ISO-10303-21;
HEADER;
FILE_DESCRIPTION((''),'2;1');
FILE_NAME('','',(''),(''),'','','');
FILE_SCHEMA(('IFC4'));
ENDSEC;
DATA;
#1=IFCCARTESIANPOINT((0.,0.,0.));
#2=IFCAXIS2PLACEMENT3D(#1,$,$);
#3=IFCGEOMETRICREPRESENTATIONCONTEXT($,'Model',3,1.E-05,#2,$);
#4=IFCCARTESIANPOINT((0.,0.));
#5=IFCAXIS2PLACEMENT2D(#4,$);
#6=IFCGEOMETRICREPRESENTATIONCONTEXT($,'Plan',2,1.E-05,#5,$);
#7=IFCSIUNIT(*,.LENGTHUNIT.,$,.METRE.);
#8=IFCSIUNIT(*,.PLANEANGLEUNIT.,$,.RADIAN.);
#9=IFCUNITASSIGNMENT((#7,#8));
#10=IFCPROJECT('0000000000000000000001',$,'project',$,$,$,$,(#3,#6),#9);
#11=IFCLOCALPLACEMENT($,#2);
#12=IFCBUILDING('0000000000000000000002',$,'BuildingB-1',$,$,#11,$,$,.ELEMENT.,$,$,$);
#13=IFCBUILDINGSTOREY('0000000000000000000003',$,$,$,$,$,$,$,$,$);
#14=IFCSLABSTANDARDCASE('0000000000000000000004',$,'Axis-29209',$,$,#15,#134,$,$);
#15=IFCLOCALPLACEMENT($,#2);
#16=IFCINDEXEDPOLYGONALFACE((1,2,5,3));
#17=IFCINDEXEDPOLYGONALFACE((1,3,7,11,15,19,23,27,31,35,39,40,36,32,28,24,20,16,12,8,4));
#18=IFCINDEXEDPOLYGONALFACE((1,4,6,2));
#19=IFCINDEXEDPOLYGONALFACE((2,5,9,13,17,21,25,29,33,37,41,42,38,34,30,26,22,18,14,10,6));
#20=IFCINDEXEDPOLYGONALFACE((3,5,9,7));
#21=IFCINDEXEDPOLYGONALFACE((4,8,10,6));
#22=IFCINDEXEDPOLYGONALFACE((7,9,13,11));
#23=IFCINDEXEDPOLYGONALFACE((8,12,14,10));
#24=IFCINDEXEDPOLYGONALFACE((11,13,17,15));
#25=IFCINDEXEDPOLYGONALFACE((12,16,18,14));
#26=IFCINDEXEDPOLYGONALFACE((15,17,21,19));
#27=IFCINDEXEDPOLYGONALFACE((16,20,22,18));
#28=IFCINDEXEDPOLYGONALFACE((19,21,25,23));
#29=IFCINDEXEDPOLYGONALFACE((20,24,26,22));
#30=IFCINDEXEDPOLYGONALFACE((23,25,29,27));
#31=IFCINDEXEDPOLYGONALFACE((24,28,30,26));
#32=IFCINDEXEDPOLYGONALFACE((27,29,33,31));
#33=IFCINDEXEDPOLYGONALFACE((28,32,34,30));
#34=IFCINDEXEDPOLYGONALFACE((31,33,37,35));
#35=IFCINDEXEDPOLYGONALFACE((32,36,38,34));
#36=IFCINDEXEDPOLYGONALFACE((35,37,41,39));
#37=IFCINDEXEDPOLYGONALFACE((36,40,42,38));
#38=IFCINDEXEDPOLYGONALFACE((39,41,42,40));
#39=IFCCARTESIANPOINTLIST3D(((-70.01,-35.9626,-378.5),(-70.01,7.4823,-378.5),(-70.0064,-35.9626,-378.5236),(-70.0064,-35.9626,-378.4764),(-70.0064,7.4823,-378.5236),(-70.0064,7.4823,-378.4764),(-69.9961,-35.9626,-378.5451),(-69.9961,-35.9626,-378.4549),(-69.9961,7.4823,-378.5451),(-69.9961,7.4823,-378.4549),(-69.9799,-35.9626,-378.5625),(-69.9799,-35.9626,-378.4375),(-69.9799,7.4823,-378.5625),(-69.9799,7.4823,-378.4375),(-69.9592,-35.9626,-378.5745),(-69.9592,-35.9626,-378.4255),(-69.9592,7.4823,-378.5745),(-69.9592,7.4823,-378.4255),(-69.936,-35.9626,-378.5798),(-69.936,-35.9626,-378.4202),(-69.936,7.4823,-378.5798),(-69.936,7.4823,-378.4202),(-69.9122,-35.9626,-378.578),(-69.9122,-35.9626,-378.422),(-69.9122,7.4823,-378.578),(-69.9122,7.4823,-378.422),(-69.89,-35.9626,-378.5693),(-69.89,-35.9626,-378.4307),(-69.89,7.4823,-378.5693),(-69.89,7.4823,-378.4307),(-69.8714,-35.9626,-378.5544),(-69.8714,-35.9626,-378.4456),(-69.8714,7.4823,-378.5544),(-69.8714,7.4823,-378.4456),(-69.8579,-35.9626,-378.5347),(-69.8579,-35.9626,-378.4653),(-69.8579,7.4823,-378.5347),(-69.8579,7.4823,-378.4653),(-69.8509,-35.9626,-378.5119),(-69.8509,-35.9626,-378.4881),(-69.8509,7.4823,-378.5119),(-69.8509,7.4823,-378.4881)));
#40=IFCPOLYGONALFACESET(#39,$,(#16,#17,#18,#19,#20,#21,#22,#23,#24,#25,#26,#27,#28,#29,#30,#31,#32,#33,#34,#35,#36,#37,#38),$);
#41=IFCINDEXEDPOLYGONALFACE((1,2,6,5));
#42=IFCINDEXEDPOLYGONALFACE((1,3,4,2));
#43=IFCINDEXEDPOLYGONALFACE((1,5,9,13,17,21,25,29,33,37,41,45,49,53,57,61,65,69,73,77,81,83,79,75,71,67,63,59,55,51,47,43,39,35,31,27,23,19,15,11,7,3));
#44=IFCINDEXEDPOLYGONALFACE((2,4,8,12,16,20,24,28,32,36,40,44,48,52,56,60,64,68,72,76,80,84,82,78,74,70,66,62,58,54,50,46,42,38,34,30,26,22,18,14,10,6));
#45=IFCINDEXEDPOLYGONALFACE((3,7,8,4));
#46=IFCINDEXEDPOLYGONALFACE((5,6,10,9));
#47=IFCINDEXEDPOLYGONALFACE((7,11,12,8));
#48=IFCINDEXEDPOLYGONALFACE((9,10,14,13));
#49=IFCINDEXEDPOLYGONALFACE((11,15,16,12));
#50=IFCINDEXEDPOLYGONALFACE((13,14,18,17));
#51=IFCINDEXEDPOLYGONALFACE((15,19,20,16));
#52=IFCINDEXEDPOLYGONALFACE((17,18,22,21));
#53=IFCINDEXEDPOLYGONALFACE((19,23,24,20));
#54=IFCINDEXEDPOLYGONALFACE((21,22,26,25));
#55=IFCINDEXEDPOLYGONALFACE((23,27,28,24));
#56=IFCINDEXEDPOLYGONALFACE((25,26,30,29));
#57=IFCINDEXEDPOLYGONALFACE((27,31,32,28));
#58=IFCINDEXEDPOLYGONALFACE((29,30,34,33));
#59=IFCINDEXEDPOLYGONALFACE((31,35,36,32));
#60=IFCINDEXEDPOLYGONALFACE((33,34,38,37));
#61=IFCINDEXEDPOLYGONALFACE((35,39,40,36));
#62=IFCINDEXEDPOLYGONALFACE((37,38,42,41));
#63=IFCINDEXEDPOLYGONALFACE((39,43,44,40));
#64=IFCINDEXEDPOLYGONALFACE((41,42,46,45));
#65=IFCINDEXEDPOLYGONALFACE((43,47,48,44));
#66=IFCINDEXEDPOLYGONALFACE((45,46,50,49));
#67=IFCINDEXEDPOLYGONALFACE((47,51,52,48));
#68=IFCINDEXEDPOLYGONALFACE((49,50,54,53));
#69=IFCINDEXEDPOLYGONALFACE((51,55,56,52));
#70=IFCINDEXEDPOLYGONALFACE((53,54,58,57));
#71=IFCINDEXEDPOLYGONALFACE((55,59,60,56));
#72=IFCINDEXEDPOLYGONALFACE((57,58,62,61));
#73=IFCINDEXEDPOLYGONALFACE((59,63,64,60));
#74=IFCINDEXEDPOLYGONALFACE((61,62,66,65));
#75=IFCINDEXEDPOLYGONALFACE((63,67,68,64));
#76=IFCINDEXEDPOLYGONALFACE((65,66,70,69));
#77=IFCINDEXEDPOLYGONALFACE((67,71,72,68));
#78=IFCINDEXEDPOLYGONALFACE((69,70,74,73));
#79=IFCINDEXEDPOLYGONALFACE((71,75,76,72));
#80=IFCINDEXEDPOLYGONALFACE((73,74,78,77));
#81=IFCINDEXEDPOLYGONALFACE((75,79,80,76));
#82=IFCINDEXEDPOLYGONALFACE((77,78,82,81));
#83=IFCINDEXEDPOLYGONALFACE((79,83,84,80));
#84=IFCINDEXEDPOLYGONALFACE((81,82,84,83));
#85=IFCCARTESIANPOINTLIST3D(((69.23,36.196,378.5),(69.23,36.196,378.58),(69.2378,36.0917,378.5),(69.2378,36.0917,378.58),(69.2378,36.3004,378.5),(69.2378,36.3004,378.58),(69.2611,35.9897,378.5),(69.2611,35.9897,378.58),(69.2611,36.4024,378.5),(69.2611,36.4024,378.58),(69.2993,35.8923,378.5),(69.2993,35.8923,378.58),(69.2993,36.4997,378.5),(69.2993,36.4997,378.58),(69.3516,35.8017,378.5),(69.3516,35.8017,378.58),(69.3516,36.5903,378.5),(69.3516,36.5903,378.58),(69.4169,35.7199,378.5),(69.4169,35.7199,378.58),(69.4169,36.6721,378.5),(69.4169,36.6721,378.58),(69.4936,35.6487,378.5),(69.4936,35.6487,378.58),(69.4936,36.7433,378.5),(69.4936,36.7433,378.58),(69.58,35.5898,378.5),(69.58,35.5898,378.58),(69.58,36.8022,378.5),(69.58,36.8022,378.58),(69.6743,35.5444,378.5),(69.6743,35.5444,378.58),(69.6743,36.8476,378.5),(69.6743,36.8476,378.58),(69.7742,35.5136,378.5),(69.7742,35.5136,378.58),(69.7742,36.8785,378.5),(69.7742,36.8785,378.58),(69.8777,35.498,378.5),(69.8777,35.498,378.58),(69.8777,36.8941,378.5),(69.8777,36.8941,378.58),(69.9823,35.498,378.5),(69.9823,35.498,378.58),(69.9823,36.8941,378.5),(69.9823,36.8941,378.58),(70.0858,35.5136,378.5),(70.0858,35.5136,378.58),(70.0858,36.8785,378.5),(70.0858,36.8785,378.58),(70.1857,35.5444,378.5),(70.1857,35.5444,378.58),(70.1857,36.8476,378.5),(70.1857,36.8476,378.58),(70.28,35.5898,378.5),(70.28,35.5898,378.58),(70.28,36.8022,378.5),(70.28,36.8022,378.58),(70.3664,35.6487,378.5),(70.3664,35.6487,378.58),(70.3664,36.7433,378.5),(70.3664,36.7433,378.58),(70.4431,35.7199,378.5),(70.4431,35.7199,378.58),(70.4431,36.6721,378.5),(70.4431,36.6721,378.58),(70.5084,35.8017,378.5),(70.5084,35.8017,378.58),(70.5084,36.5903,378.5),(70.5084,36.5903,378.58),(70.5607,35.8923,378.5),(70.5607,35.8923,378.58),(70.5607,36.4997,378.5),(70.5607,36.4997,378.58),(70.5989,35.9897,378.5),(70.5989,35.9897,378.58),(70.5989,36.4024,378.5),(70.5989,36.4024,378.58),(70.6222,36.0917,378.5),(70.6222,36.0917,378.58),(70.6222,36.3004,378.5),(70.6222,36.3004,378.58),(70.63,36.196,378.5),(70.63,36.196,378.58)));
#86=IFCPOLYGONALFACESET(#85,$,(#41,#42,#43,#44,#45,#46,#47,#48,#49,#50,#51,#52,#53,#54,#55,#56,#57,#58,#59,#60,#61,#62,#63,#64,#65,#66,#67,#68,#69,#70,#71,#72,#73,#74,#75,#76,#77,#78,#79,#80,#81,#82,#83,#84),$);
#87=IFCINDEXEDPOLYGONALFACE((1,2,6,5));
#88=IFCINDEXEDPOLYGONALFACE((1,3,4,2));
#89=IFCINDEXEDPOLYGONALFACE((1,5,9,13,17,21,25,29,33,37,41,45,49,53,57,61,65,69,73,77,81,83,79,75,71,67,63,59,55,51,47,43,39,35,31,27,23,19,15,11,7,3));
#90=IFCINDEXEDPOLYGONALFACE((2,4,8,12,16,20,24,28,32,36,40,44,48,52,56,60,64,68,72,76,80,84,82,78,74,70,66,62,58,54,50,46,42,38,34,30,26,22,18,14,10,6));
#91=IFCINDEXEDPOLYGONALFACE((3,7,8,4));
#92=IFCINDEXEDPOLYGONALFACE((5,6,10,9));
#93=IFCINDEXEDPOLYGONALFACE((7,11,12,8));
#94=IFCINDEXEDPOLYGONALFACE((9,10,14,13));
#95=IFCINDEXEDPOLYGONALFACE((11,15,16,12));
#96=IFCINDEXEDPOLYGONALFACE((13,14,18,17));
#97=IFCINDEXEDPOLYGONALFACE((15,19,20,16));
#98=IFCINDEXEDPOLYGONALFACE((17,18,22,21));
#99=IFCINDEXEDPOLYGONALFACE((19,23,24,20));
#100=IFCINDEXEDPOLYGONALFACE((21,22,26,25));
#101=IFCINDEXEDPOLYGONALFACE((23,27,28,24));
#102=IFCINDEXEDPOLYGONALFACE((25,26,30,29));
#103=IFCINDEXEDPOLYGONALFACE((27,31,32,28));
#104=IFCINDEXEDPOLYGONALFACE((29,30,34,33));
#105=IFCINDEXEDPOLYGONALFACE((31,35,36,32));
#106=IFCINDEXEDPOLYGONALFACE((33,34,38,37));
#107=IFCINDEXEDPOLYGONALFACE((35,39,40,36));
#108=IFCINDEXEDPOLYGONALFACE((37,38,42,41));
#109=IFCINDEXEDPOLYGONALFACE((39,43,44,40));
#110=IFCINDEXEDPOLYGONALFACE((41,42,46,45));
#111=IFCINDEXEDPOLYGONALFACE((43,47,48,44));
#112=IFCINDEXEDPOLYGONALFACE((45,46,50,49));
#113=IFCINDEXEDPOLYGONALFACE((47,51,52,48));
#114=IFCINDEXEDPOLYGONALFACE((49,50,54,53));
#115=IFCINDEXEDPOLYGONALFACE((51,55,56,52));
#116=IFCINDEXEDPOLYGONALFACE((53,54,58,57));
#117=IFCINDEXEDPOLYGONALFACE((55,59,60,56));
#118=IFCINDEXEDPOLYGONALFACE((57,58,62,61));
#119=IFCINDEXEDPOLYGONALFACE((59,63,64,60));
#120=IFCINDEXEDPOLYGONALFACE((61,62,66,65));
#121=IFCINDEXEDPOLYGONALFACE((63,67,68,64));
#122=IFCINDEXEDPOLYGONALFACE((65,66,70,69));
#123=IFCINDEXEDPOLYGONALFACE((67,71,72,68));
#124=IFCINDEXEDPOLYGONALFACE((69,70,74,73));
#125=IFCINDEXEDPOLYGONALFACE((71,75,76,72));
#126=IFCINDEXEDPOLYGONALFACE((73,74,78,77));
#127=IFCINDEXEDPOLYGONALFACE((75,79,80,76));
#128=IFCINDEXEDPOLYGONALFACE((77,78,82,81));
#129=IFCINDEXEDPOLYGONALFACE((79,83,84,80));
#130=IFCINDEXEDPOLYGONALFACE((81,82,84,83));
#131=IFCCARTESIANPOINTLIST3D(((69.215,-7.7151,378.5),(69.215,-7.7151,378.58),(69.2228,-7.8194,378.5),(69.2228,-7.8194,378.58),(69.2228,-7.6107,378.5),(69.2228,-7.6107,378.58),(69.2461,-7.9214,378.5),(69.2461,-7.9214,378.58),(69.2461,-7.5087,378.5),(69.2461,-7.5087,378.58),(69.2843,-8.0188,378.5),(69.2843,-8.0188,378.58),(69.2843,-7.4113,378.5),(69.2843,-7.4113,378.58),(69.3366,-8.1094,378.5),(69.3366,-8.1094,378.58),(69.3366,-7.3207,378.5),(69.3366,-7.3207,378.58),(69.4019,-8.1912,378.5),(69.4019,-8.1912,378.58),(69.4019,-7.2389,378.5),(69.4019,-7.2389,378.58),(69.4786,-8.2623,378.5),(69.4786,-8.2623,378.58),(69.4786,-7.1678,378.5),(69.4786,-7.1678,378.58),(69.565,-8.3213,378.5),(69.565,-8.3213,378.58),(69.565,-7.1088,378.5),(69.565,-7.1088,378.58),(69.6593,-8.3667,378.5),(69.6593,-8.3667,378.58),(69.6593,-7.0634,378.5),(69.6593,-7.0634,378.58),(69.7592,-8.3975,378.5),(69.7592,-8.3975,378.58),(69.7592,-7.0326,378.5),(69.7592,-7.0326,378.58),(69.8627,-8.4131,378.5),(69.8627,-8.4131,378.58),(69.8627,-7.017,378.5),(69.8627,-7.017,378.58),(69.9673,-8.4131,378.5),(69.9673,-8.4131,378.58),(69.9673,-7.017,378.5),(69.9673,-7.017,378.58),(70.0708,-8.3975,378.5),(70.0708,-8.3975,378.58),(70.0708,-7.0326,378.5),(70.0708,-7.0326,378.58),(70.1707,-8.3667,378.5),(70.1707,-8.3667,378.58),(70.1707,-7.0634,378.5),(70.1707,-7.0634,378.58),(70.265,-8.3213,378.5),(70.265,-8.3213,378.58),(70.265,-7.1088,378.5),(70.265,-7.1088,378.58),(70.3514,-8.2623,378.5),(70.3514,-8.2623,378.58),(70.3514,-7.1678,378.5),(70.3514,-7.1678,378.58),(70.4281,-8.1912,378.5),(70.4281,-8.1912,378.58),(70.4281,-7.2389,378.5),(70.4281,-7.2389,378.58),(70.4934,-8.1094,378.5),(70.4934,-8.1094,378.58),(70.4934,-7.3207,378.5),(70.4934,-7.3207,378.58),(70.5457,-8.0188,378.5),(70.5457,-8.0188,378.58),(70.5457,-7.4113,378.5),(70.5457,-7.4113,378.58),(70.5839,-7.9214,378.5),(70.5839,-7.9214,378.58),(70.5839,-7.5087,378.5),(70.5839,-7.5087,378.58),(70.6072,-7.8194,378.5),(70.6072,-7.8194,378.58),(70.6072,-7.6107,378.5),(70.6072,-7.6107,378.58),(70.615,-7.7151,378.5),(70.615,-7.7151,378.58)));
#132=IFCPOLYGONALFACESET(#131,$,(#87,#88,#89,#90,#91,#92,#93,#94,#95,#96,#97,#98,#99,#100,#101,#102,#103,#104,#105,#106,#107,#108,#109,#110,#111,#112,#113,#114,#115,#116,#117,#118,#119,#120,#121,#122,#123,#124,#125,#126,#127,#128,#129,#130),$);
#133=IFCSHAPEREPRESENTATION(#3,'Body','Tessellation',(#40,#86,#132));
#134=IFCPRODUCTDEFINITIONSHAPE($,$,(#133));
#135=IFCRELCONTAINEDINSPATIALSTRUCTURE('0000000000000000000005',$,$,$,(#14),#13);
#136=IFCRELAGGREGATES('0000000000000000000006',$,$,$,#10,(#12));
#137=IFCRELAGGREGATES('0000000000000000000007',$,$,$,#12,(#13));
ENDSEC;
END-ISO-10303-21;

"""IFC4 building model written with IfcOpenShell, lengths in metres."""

from ifc_helpers import new_model, entity, si_unit, frame, origin, origin_2d, place, context, project, spatial, circle, extrude, element, save


model = new_model("IFC4")

# Units and contexts
model_context = context("Model", 3, precision=1e-05, world=origin())
plan_context = context("Plan", 2, precision=1e-05, world=origin_2d())
ifc_project = project(units=[si_unit("LENGTHUNIT", "METRE"), si_unit("PLANEANGLEUNIT", "RADIAN")], contexts=[model_context, plan_context])

# Building, storey
building_placement = place(None, origin())
building = spatial("IfcBuilding", under=ifc_project, at=building_placement, Name="BuildingB-1", CompositionType="ELEMENT")
storey = spatial("IfcBuildingStorey", under=building)

# Slab
element("IfcSlabStandardCase", 1, inside=storey, Name="Axis-29209", context=model_context, shape_type="AdvancedSweptSolid", body=[
    entity("IfcSurfaceCurveSweptAreaSolid", entity("IfcCircleProfileDef", "AREA", None, None, 0.08), None, entity("IfcPolyline", [entity("IfcCartesianPoint", [69.93, 35.9626, 378.5]), entity("IfcCartesianPoint", [69.93, -7.4823, 378.5])]), None, None, entity("IfcPlane", entity("IfcAxis2Placement3D", entity("IfcCartesianPoint", [69.93, 35.9626, 378.5]), entity("IfcDirection", [0.0, 0.0, 1.0]), entity("IfcDirection", [1.0, 0.0, 0.0])))),
    extrude(circle(Radius=0.7), frame((69.93, 36.196, 378.5)), (0.0, 0.0, 1.0), 0.08),
    extrude(circle(Radius=0.7), frame((69.915, -7.7151, 378.5)), (0.0, 0.0, 1.0), 0.08),
])

save(model, "model.ifc")
